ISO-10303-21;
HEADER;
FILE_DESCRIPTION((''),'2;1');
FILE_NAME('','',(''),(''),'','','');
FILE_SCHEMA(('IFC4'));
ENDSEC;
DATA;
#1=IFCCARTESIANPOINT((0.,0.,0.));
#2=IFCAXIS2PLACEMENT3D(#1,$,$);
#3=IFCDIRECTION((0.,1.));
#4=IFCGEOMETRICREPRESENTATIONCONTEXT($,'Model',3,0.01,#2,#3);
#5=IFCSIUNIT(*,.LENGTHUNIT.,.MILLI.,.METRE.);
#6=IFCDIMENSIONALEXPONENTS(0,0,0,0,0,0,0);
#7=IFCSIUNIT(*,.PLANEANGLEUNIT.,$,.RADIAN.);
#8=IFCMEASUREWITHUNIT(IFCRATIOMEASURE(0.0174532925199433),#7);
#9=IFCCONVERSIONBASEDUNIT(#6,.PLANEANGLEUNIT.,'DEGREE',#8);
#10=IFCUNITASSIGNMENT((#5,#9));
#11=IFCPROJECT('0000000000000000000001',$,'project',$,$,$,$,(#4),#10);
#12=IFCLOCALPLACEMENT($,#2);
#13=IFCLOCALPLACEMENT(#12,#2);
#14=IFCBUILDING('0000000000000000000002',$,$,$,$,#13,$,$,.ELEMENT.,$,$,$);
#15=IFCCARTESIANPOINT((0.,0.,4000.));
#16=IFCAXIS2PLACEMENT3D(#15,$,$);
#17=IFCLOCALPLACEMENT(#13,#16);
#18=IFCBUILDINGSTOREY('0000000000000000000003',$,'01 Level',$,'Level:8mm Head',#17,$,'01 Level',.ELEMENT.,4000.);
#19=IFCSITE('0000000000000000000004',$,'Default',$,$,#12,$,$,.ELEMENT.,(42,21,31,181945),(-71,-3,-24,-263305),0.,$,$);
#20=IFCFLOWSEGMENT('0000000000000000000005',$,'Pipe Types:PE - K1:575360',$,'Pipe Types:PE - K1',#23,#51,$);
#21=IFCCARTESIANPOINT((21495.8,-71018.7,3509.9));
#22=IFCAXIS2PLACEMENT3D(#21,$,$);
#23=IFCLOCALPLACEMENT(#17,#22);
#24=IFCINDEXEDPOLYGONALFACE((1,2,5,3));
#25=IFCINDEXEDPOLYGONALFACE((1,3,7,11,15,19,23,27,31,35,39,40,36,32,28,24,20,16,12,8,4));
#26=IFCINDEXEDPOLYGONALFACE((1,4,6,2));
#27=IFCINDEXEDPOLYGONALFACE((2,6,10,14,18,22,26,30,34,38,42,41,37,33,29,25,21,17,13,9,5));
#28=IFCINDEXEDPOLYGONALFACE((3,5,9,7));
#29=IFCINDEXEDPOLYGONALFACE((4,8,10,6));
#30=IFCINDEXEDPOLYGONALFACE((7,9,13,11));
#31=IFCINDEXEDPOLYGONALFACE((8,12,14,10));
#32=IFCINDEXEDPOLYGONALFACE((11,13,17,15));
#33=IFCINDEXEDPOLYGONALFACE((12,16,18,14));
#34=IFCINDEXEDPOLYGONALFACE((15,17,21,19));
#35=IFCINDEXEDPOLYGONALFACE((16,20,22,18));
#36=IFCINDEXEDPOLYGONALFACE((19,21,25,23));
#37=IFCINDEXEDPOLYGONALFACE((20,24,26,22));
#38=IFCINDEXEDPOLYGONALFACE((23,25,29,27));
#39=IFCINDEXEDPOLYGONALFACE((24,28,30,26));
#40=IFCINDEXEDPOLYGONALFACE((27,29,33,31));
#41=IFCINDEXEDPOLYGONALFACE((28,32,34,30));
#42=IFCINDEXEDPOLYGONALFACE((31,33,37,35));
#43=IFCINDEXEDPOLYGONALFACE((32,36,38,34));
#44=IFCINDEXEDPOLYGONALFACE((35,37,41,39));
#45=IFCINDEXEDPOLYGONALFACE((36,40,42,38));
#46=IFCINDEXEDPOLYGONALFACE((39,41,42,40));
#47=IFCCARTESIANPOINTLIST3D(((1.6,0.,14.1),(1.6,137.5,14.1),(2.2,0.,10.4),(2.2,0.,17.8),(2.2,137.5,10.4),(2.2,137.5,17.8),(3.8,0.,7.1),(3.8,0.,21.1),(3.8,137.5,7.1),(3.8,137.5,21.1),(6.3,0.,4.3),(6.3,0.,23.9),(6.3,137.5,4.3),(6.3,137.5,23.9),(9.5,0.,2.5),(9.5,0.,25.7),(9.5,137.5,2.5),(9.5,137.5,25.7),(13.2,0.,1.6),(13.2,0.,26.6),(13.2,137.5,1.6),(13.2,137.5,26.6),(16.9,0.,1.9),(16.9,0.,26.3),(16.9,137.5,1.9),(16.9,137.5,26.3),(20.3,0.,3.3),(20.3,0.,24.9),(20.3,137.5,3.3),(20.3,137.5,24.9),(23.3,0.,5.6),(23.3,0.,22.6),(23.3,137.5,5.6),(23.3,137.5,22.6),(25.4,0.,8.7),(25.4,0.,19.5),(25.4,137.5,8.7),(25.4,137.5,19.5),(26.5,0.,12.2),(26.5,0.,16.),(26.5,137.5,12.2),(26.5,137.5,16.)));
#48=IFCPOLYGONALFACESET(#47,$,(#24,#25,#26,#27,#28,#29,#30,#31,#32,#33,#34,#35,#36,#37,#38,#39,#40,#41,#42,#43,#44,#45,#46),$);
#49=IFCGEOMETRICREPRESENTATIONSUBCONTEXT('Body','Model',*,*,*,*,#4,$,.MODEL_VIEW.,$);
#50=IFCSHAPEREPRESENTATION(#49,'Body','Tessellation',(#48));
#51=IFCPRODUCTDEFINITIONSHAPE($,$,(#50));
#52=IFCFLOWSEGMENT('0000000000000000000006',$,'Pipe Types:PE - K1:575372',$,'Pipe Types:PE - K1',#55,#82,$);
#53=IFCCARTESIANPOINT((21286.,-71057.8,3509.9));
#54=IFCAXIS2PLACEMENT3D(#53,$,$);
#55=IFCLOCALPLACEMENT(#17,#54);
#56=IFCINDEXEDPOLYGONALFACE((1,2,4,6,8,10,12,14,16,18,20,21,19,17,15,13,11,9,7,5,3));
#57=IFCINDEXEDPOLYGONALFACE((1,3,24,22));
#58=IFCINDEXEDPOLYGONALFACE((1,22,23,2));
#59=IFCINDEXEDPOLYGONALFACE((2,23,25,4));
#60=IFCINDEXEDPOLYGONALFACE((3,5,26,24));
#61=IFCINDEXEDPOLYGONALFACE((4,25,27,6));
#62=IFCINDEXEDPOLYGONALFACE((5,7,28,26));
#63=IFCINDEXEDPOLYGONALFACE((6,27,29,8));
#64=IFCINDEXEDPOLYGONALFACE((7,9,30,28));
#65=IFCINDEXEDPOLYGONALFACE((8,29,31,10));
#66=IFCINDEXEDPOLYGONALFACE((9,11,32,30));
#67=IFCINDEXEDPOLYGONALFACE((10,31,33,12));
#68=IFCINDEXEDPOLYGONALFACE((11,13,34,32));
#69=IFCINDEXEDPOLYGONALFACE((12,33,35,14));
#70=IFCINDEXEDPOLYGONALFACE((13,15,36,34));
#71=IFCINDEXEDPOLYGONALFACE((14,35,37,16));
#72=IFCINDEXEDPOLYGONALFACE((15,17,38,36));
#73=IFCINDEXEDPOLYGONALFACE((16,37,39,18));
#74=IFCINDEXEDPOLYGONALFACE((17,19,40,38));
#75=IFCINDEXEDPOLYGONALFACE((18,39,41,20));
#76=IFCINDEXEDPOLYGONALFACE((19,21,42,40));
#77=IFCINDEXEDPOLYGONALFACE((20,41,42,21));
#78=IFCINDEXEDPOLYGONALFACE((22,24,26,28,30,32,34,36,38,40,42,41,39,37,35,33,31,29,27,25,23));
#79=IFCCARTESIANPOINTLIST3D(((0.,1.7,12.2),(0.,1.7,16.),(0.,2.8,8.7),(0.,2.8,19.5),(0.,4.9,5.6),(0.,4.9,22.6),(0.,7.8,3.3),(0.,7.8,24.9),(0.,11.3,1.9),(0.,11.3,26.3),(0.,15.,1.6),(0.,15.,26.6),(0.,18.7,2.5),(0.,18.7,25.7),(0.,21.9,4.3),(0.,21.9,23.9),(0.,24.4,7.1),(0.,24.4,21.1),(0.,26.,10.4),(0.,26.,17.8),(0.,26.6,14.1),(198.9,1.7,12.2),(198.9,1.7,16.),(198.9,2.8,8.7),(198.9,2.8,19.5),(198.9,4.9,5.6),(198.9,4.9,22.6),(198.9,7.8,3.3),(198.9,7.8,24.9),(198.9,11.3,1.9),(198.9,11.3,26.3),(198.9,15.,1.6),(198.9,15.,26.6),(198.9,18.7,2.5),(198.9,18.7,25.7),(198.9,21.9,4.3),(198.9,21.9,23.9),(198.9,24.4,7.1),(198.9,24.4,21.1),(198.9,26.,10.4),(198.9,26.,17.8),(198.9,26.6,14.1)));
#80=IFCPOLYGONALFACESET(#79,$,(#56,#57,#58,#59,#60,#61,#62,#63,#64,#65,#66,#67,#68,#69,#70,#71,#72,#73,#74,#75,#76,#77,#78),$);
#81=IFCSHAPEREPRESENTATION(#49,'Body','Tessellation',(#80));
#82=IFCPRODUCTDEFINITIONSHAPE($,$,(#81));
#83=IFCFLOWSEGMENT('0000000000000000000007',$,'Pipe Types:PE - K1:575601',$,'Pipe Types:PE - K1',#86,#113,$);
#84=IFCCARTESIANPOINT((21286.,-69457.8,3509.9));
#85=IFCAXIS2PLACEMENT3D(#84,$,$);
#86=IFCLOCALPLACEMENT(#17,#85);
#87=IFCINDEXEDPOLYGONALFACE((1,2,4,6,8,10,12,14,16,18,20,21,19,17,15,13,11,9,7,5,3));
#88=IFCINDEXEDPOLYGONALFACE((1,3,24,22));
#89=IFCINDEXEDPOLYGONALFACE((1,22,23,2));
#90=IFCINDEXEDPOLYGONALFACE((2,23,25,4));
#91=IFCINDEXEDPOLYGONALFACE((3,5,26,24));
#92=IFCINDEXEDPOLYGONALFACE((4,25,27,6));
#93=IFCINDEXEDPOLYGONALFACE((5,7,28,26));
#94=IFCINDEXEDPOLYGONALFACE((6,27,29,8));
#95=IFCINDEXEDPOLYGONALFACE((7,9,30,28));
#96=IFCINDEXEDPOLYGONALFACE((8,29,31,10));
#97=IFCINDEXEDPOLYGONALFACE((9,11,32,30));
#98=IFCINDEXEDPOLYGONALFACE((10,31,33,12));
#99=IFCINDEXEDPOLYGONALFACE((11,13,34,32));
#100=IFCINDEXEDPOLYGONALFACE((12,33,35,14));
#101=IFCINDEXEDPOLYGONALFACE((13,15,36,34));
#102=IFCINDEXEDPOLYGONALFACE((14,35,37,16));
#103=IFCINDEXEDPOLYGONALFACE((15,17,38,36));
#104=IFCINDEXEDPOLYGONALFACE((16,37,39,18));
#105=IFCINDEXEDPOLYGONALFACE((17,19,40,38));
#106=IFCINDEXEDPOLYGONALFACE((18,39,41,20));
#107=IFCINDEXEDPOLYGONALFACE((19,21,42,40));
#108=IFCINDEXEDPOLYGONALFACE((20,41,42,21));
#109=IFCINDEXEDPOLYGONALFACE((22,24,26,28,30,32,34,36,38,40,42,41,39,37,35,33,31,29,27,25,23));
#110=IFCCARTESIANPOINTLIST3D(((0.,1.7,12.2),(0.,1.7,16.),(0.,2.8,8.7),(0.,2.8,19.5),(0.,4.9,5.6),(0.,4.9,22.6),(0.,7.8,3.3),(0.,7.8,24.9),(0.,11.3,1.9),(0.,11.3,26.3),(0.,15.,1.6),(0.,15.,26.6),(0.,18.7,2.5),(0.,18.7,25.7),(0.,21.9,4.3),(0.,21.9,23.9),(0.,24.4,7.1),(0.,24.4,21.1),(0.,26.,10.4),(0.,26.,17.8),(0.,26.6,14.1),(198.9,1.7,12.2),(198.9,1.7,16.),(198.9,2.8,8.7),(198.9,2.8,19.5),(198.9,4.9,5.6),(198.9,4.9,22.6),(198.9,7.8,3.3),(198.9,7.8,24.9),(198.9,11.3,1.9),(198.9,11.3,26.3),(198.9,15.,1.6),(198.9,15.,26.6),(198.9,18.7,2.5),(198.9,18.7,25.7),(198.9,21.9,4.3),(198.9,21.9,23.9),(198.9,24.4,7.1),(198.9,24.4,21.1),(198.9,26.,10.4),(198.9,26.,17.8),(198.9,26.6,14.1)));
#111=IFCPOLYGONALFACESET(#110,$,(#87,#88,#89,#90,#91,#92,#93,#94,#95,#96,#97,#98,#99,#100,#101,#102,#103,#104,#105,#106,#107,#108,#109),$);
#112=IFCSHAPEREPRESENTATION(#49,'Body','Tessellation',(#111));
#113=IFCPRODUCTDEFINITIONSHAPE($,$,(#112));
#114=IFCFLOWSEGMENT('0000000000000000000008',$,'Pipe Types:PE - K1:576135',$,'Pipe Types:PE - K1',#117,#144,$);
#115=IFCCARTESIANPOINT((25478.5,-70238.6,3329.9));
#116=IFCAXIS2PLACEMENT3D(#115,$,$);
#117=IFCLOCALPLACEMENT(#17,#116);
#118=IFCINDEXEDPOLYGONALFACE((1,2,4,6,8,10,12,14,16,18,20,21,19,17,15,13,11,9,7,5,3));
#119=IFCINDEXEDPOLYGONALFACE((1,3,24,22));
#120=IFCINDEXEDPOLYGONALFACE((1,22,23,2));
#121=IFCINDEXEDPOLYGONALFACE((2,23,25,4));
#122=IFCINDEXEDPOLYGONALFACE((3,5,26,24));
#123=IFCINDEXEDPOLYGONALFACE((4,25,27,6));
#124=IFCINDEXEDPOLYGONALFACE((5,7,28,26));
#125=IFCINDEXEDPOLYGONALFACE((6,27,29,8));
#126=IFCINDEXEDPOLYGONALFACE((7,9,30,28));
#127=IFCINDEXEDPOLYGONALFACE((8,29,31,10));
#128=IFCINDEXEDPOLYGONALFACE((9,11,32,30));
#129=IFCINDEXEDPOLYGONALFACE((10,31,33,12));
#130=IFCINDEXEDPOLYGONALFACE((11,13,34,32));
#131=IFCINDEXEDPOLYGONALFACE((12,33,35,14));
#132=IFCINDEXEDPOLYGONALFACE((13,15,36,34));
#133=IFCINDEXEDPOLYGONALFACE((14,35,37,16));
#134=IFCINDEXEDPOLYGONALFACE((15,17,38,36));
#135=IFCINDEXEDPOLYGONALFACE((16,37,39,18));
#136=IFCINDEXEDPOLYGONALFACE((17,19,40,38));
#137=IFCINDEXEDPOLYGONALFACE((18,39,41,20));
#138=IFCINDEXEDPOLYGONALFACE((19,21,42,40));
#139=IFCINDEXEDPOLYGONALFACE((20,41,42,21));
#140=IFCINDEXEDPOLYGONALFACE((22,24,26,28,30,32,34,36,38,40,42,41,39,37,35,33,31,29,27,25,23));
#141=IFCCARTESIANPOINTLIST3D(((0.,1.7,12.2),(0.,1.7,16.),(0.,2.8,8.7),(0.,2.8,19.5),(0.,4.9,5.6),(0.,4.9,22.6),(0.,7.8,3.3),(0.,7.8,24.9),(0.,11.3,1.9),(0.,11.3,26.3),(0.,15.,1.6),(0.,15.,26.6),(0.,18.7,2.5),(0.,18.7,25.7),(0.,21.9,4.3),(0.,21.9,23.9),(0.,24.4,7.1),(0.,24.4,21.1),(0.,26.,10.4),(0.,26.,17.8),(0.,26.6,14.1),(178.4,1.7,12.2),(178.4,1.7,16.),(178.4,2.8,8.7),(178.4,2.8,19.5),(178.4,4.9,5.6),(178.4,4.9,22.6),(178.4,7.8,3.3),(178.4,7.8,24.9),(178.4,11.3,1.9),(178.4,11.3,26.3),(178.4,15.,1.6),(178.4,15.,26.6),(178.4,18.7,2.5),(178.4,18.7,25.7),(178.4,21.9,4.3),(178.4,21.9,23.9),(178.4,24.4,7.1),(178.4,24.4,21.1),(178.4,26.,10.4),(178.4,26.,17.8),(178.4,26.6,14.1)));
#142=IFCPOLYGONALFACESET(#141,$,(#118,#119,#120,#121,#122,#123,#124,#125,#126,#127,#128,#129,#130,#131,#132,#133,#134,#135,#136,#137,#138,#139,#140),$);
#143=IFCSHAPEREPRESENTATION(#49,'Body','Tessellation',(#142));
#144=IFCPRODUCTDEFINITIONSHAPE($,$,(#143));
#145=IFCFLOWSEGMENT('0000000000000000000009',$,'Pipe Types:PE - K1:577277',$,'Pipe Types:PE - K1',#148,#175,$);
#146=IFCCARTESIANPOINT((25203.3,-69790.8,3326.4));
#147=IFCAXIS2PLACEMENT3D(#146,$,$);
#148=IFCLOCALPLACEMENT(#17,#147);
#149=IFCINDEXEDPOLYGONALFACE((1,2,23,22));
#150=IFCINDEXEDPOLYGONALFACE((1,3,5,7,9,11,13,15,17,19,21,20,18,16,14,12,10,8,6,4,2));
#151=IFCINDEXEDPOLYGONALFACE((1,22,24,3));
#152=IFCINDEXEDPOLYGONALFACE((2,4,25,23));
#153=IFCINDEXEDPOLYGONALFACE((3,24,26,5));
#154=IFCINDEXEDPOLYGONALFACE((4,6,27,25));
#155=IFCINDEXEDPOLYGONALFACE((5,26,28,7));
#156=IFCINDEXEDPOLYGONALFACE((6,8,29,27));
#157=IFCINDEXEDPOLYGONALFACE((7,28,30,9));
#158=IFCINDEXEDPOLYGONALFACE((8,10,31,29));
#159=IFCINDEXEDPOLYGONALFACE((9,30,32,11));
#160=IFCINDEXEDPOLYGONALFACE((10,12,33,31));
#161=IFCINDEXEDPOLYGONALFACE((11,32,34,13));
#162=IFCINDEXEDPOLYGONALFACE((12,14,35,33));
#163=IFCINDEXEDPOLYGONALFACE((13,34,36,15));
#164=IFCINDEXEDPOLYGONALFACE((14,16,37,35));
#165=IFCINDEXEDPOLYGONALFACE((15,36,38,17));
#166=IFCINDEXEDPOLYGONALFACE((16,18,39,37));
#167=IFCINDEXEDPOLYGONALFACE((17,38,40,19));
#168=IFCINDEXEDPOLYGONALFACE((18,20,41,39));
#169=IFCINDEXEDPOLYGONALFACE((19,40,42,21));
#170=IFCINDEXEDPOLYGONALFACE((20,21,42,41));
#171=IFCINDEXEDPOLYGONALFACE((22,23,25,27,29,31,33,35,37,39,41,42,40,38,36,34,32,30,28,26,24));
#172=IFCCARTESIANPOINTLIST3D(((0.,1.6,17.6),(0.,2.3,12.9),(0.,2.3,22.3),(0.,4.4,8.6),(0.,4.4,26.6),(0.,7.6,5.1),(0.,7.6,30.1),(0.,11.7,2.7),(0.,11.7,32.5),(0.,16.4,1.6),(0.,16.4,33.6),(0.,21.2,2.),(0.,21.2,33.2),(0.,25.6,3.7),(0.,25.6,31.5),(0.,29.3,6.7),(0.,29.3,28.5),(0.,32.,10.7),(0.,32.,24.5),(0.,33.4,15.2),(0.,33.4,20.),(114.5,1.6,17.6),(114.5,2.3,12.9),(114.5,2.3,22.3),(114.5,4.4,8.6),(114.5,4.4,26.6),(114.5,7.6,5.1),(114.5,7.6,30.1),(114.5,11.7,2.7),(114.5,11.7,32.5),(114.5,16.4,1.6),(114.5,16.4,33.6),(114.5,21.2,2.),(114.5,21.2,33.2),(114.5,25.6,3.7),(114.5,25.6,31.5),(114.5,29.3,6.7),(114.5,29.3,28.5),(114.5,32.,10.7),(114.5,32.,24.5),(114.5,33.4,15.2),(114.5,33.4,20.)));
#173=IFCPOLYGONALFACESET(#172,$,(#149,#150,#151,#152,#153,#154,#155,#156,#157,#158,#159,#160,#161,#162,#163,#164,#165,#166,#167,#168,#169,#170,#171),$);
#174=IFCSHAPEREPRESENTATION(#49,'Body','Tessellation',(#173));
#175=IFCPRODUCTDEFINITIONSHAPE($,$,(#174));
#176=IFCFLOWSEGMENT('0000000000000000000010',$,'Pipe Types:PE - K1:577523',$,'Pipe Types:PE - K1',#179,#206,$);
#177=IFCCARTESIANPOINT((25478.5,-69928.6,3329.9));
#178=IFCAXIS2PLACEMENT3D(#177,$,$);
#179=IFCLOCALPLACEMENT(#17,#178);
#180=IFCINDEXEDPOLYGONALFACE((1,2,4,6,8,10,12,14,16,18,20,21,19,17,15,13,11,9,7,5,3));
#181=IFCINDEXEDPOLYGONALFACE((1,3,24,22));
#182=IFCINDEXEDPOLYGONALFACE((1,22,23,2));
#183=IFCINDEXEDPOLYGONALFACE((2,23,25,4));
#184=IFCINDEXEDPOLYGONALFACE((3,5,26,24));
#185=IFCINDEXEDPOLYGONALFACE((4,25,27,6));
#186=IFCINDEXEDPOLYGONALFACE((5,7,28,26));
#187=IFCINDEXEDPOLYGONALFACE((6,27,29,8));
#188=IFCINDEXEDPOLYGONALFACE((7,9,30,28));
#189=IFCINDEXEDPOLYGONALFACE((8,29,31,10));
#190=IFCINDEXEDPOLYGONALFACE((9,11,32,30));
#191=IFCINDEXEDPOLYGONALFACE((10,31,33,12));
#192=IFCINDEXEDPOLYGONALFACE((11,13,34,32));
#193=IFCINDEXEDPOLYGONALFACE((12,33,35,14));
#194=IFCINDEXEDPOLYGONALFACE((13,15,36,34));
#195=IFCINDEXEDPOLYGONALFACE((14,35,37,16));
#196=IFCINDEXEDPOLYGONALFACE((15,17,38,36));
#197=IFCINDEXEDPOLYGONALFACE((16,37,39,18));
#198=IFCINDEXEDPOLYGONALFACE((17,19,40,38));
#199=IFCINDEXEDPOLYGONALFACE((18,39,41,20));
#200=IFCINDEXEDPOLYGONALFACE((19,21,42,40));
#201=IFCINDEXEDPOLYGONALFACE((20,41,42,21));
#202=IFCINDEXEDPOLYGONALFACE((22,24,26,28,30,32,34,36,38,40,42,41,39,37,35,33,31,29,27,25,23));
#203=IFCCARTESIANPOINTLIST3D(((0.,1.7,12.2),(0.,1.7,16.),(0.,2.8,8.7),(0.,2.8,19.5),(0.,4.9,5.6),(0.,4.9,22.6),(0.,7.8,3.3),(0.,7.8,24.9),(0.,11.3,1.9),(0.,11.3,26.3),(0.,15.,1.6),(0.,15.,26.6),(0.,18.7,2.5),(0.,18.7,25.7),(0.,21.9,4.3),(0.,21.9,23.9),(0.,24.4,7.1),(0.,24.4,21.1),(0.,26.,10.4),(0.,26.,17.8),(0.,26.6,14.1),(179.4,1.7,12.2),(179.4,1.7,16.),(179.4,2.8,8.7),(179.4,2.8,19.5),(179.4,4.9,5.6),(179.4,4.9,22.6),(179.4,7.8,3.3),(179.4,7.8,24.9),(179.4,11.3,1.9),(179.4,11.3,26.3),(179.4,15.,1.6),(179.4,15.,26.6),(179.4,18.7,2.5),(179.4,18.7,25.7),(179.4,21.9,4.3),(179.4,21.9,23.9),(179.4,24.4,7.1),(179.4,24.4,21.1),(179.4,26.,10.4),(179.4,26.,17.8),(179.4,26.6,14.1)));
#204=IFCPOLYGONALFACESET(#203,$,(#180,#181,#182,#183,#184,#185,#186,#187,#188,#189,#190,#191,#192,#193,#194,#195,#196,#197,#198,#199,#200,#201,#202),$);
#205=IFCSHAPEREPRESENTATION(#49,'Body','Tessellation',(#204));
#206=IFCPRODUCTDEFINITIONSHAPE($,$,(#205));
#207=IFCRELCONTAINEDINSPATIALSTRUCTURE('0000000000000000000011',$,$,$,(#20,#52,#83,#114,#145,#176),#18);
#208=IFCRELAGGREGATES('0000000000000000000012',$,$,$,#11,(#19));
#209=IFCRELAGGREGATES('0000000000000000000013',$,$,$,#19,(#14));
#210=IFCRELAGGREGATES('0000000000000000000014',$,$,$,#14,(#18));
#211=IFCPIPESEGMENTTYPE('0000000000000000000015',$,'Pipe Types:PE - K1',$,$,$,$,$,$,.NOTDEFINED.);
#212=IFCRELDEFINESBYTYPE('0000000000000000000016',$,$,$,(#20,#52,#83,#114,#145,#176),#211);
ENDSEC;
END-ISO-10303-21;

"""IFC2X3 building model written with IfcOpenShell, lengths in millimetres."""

from ifc_helpers import new_model, entity, si_unit, converted_unit, direction, frame, frame_2d, origin, origin_2d_with_axis, place, context, subcontext, project, spatial, circle, extrude, type_object, element, save


model = new_model("IFC2X3")

# Units and contexts
model_context = context("Model", 3, precision=0.01, world=origin(), true_north=direction((0.0, 1.0)))
body_context = subcontext(model_context, "Body", "Model", "MODEL_VIEW")
ifc_project = project(units=[si_unit("LENGTHUNIT", "METRE", prefix="MILLI"), converted_unit("PLANEANGLEUNIT", "DEGREE", entity("IfcRatioMeasure", 0.0174532925199433), si_unit("PLANEANGLEUNIT", "RADIAN"), dimensions=[0, 0, 0, 0, 0, 0, 0])], contexts=[model_context])

# Site, building, storey
site_placement = place(None, origin())
site = spatial("IfcSite", under=ifc_project, at=site_placement, Name="Default", CompositionType="ELEMENT", RefLatitude=(42, 21, 31, 181945), RefLongitude=(-71, -3, -24, -263305), RefElevation=0.0)
building_placement = place(site_placement, origin())
building = spatial("IfcBuilding", under=site, at=building_placement, CompositionType="ELEMENT")
storey_placement = place(building_placement, frame((0.0, 0.0, 4000.0)))
storey = spatial("IfcBuildingStorey", under=building, at=storey_placement, Name="01 Level", ObjectType="Level:8mm Head", LongName="01 Level", CompositionType="ELEMENT", Elevation=4000.0)

# Flow segments
pipe_segment_type = type_object("IfcPipeSegmentType", Name="Pipe Types:PE - K1", PredefinedType="NOTDEFINED")
flow_segment_1_placement = place(storey_placement, frame((21495.8, -71018.7, 3509.9)))
element("IfcFlowSegment", 1, at=flow_segment_1_placement, inside=storey, type_object=pipe_segment_type, Name="Pipe Types:PE - K1:575360", ObjectType="Pipe Types:PE - K1", context=body_context, shape_type="SweptSolid", body=[
    extrude(circle(Radius=12.5, at=origin_2d_with_axis()), frame((14.1, 0.0, 14.1), z_axis=(0.0, 1.0, 0.0), x_axis=(-1.0, 0.0, 0.0)), (0.0, 0.0, 1.0), 137.5),
])
flow_segment_2_placement = place(storey_placement, frame((21286.0, -71057.8, 3509.9)))
element("IfcFlowSegment", 2, at=flow_segment_2_placement, inside=storey, type_object=pipe_segment_type, Name="Pipe Types:PE - K1:575372", ObjectType="Pipe Types:PE - K1", context=body_context, shape_type="SweptSolid", body=[
    extrude(circle(Radius=12.5, at=frame_2d((0.0, 0.0), x_axis=(1.0, 0.0))), frame((0.0, 14.1, 14.1), z_axis=(1.0, 0.0, 0.0), x_axis=(0.0, 1.0, 0.0)), (0.0, 0.0, 1.0), 198.9),
])
flow_segment_3_placement = place(storey_placement, frame((21286.0, -69457.8, 3509.9)))
element("IfcFlowSegment", 3, at=flow_segment_3_placement, inside=storey, type_object=pipe_segment_type, Name="Pipe Types:PE - K1:575601", ObjectType="Pipe Types:PE - K1", context=body_context, shape_type="SweptSolid", body=[
    extrude(circle(Radius=12.5, at=frame_2d((0.0, 0.0), x_axis=(1.0, 0.0))), frame((0.0, 14.1, 14.1), z_axis=(1.0, 0.0, 0.0), x_axis=(0.0, 1.0, 0.0)), (0.0, 0.0, 1.0), 198.9),
])
flow_segment_4_placement = place(storey_placement, frame((25478.5, -70238.6, 3329.9)))
element("IfcFlowSegment", 4, at=flow_segment_4_placement, inside=storey, type_object=pipe_segment_type, Name="Pipe Types:PE - K1:576135", ObjectType="Pipe Types:PE - K1", context=body_context, shape_type="SweptSolid", body=[
    extrude(circle(Radius=12.5, at=origin_2d_with_axis()), frame((0.0, 14.1, 14.1), z_axis=(1.0, 0.0, 0.0), x_axis=(0.0, 1.0, 0.0)), (0.0, 0.0, 1.0), 178.4),
])
flow_segment_5_placement = place(storey_placement, frame((25203.3, -69790.8, 3326.4)))
element("IfcFlowSegment", 5, at=flow_segment_5_placement, inside=storey, type_object=pipe_segment_type, Name="Pipe Types:PE - K1:577277", ObjectType="Pipe Types:PE - K1", context=body_context, shape_type="SweptSolid", body=[
    extrude(circle(Radius=16.0, at=origin_2d_with_axis()), frame((0.0, 17.6, 17.6), z_axis=(1.0, 0.0, 0.0), x_axis=(0.0, -1.0, 0.0)), (0.0, 0.0, 1.0), 114.5),
])
flow_segment_6_placement = place(storey_placement, frame((25478.5, -69928.6, 3329.9)))
element("IfcFlowSegment", 6, at=flow_segment_6_placement, inside=storey, type_object=pipe_segment_type, Name="Pipe Types:PE - K1:577523", ObjectType="Pipe Types:PE - K1", context=body_context, shape_type="SweptSolid", body=[
    extrude(circle(Radius=12.5, at=origin_2d_with_axis()), frame((0.0, 14.1, 14.1), z_axis=(1.0, 0.0, 0.0), x_axis=(0.0, 1.0, 0.0)), (0.0, 0.0, 1.0), 179.4),
])

save(model, "model.ifc")
